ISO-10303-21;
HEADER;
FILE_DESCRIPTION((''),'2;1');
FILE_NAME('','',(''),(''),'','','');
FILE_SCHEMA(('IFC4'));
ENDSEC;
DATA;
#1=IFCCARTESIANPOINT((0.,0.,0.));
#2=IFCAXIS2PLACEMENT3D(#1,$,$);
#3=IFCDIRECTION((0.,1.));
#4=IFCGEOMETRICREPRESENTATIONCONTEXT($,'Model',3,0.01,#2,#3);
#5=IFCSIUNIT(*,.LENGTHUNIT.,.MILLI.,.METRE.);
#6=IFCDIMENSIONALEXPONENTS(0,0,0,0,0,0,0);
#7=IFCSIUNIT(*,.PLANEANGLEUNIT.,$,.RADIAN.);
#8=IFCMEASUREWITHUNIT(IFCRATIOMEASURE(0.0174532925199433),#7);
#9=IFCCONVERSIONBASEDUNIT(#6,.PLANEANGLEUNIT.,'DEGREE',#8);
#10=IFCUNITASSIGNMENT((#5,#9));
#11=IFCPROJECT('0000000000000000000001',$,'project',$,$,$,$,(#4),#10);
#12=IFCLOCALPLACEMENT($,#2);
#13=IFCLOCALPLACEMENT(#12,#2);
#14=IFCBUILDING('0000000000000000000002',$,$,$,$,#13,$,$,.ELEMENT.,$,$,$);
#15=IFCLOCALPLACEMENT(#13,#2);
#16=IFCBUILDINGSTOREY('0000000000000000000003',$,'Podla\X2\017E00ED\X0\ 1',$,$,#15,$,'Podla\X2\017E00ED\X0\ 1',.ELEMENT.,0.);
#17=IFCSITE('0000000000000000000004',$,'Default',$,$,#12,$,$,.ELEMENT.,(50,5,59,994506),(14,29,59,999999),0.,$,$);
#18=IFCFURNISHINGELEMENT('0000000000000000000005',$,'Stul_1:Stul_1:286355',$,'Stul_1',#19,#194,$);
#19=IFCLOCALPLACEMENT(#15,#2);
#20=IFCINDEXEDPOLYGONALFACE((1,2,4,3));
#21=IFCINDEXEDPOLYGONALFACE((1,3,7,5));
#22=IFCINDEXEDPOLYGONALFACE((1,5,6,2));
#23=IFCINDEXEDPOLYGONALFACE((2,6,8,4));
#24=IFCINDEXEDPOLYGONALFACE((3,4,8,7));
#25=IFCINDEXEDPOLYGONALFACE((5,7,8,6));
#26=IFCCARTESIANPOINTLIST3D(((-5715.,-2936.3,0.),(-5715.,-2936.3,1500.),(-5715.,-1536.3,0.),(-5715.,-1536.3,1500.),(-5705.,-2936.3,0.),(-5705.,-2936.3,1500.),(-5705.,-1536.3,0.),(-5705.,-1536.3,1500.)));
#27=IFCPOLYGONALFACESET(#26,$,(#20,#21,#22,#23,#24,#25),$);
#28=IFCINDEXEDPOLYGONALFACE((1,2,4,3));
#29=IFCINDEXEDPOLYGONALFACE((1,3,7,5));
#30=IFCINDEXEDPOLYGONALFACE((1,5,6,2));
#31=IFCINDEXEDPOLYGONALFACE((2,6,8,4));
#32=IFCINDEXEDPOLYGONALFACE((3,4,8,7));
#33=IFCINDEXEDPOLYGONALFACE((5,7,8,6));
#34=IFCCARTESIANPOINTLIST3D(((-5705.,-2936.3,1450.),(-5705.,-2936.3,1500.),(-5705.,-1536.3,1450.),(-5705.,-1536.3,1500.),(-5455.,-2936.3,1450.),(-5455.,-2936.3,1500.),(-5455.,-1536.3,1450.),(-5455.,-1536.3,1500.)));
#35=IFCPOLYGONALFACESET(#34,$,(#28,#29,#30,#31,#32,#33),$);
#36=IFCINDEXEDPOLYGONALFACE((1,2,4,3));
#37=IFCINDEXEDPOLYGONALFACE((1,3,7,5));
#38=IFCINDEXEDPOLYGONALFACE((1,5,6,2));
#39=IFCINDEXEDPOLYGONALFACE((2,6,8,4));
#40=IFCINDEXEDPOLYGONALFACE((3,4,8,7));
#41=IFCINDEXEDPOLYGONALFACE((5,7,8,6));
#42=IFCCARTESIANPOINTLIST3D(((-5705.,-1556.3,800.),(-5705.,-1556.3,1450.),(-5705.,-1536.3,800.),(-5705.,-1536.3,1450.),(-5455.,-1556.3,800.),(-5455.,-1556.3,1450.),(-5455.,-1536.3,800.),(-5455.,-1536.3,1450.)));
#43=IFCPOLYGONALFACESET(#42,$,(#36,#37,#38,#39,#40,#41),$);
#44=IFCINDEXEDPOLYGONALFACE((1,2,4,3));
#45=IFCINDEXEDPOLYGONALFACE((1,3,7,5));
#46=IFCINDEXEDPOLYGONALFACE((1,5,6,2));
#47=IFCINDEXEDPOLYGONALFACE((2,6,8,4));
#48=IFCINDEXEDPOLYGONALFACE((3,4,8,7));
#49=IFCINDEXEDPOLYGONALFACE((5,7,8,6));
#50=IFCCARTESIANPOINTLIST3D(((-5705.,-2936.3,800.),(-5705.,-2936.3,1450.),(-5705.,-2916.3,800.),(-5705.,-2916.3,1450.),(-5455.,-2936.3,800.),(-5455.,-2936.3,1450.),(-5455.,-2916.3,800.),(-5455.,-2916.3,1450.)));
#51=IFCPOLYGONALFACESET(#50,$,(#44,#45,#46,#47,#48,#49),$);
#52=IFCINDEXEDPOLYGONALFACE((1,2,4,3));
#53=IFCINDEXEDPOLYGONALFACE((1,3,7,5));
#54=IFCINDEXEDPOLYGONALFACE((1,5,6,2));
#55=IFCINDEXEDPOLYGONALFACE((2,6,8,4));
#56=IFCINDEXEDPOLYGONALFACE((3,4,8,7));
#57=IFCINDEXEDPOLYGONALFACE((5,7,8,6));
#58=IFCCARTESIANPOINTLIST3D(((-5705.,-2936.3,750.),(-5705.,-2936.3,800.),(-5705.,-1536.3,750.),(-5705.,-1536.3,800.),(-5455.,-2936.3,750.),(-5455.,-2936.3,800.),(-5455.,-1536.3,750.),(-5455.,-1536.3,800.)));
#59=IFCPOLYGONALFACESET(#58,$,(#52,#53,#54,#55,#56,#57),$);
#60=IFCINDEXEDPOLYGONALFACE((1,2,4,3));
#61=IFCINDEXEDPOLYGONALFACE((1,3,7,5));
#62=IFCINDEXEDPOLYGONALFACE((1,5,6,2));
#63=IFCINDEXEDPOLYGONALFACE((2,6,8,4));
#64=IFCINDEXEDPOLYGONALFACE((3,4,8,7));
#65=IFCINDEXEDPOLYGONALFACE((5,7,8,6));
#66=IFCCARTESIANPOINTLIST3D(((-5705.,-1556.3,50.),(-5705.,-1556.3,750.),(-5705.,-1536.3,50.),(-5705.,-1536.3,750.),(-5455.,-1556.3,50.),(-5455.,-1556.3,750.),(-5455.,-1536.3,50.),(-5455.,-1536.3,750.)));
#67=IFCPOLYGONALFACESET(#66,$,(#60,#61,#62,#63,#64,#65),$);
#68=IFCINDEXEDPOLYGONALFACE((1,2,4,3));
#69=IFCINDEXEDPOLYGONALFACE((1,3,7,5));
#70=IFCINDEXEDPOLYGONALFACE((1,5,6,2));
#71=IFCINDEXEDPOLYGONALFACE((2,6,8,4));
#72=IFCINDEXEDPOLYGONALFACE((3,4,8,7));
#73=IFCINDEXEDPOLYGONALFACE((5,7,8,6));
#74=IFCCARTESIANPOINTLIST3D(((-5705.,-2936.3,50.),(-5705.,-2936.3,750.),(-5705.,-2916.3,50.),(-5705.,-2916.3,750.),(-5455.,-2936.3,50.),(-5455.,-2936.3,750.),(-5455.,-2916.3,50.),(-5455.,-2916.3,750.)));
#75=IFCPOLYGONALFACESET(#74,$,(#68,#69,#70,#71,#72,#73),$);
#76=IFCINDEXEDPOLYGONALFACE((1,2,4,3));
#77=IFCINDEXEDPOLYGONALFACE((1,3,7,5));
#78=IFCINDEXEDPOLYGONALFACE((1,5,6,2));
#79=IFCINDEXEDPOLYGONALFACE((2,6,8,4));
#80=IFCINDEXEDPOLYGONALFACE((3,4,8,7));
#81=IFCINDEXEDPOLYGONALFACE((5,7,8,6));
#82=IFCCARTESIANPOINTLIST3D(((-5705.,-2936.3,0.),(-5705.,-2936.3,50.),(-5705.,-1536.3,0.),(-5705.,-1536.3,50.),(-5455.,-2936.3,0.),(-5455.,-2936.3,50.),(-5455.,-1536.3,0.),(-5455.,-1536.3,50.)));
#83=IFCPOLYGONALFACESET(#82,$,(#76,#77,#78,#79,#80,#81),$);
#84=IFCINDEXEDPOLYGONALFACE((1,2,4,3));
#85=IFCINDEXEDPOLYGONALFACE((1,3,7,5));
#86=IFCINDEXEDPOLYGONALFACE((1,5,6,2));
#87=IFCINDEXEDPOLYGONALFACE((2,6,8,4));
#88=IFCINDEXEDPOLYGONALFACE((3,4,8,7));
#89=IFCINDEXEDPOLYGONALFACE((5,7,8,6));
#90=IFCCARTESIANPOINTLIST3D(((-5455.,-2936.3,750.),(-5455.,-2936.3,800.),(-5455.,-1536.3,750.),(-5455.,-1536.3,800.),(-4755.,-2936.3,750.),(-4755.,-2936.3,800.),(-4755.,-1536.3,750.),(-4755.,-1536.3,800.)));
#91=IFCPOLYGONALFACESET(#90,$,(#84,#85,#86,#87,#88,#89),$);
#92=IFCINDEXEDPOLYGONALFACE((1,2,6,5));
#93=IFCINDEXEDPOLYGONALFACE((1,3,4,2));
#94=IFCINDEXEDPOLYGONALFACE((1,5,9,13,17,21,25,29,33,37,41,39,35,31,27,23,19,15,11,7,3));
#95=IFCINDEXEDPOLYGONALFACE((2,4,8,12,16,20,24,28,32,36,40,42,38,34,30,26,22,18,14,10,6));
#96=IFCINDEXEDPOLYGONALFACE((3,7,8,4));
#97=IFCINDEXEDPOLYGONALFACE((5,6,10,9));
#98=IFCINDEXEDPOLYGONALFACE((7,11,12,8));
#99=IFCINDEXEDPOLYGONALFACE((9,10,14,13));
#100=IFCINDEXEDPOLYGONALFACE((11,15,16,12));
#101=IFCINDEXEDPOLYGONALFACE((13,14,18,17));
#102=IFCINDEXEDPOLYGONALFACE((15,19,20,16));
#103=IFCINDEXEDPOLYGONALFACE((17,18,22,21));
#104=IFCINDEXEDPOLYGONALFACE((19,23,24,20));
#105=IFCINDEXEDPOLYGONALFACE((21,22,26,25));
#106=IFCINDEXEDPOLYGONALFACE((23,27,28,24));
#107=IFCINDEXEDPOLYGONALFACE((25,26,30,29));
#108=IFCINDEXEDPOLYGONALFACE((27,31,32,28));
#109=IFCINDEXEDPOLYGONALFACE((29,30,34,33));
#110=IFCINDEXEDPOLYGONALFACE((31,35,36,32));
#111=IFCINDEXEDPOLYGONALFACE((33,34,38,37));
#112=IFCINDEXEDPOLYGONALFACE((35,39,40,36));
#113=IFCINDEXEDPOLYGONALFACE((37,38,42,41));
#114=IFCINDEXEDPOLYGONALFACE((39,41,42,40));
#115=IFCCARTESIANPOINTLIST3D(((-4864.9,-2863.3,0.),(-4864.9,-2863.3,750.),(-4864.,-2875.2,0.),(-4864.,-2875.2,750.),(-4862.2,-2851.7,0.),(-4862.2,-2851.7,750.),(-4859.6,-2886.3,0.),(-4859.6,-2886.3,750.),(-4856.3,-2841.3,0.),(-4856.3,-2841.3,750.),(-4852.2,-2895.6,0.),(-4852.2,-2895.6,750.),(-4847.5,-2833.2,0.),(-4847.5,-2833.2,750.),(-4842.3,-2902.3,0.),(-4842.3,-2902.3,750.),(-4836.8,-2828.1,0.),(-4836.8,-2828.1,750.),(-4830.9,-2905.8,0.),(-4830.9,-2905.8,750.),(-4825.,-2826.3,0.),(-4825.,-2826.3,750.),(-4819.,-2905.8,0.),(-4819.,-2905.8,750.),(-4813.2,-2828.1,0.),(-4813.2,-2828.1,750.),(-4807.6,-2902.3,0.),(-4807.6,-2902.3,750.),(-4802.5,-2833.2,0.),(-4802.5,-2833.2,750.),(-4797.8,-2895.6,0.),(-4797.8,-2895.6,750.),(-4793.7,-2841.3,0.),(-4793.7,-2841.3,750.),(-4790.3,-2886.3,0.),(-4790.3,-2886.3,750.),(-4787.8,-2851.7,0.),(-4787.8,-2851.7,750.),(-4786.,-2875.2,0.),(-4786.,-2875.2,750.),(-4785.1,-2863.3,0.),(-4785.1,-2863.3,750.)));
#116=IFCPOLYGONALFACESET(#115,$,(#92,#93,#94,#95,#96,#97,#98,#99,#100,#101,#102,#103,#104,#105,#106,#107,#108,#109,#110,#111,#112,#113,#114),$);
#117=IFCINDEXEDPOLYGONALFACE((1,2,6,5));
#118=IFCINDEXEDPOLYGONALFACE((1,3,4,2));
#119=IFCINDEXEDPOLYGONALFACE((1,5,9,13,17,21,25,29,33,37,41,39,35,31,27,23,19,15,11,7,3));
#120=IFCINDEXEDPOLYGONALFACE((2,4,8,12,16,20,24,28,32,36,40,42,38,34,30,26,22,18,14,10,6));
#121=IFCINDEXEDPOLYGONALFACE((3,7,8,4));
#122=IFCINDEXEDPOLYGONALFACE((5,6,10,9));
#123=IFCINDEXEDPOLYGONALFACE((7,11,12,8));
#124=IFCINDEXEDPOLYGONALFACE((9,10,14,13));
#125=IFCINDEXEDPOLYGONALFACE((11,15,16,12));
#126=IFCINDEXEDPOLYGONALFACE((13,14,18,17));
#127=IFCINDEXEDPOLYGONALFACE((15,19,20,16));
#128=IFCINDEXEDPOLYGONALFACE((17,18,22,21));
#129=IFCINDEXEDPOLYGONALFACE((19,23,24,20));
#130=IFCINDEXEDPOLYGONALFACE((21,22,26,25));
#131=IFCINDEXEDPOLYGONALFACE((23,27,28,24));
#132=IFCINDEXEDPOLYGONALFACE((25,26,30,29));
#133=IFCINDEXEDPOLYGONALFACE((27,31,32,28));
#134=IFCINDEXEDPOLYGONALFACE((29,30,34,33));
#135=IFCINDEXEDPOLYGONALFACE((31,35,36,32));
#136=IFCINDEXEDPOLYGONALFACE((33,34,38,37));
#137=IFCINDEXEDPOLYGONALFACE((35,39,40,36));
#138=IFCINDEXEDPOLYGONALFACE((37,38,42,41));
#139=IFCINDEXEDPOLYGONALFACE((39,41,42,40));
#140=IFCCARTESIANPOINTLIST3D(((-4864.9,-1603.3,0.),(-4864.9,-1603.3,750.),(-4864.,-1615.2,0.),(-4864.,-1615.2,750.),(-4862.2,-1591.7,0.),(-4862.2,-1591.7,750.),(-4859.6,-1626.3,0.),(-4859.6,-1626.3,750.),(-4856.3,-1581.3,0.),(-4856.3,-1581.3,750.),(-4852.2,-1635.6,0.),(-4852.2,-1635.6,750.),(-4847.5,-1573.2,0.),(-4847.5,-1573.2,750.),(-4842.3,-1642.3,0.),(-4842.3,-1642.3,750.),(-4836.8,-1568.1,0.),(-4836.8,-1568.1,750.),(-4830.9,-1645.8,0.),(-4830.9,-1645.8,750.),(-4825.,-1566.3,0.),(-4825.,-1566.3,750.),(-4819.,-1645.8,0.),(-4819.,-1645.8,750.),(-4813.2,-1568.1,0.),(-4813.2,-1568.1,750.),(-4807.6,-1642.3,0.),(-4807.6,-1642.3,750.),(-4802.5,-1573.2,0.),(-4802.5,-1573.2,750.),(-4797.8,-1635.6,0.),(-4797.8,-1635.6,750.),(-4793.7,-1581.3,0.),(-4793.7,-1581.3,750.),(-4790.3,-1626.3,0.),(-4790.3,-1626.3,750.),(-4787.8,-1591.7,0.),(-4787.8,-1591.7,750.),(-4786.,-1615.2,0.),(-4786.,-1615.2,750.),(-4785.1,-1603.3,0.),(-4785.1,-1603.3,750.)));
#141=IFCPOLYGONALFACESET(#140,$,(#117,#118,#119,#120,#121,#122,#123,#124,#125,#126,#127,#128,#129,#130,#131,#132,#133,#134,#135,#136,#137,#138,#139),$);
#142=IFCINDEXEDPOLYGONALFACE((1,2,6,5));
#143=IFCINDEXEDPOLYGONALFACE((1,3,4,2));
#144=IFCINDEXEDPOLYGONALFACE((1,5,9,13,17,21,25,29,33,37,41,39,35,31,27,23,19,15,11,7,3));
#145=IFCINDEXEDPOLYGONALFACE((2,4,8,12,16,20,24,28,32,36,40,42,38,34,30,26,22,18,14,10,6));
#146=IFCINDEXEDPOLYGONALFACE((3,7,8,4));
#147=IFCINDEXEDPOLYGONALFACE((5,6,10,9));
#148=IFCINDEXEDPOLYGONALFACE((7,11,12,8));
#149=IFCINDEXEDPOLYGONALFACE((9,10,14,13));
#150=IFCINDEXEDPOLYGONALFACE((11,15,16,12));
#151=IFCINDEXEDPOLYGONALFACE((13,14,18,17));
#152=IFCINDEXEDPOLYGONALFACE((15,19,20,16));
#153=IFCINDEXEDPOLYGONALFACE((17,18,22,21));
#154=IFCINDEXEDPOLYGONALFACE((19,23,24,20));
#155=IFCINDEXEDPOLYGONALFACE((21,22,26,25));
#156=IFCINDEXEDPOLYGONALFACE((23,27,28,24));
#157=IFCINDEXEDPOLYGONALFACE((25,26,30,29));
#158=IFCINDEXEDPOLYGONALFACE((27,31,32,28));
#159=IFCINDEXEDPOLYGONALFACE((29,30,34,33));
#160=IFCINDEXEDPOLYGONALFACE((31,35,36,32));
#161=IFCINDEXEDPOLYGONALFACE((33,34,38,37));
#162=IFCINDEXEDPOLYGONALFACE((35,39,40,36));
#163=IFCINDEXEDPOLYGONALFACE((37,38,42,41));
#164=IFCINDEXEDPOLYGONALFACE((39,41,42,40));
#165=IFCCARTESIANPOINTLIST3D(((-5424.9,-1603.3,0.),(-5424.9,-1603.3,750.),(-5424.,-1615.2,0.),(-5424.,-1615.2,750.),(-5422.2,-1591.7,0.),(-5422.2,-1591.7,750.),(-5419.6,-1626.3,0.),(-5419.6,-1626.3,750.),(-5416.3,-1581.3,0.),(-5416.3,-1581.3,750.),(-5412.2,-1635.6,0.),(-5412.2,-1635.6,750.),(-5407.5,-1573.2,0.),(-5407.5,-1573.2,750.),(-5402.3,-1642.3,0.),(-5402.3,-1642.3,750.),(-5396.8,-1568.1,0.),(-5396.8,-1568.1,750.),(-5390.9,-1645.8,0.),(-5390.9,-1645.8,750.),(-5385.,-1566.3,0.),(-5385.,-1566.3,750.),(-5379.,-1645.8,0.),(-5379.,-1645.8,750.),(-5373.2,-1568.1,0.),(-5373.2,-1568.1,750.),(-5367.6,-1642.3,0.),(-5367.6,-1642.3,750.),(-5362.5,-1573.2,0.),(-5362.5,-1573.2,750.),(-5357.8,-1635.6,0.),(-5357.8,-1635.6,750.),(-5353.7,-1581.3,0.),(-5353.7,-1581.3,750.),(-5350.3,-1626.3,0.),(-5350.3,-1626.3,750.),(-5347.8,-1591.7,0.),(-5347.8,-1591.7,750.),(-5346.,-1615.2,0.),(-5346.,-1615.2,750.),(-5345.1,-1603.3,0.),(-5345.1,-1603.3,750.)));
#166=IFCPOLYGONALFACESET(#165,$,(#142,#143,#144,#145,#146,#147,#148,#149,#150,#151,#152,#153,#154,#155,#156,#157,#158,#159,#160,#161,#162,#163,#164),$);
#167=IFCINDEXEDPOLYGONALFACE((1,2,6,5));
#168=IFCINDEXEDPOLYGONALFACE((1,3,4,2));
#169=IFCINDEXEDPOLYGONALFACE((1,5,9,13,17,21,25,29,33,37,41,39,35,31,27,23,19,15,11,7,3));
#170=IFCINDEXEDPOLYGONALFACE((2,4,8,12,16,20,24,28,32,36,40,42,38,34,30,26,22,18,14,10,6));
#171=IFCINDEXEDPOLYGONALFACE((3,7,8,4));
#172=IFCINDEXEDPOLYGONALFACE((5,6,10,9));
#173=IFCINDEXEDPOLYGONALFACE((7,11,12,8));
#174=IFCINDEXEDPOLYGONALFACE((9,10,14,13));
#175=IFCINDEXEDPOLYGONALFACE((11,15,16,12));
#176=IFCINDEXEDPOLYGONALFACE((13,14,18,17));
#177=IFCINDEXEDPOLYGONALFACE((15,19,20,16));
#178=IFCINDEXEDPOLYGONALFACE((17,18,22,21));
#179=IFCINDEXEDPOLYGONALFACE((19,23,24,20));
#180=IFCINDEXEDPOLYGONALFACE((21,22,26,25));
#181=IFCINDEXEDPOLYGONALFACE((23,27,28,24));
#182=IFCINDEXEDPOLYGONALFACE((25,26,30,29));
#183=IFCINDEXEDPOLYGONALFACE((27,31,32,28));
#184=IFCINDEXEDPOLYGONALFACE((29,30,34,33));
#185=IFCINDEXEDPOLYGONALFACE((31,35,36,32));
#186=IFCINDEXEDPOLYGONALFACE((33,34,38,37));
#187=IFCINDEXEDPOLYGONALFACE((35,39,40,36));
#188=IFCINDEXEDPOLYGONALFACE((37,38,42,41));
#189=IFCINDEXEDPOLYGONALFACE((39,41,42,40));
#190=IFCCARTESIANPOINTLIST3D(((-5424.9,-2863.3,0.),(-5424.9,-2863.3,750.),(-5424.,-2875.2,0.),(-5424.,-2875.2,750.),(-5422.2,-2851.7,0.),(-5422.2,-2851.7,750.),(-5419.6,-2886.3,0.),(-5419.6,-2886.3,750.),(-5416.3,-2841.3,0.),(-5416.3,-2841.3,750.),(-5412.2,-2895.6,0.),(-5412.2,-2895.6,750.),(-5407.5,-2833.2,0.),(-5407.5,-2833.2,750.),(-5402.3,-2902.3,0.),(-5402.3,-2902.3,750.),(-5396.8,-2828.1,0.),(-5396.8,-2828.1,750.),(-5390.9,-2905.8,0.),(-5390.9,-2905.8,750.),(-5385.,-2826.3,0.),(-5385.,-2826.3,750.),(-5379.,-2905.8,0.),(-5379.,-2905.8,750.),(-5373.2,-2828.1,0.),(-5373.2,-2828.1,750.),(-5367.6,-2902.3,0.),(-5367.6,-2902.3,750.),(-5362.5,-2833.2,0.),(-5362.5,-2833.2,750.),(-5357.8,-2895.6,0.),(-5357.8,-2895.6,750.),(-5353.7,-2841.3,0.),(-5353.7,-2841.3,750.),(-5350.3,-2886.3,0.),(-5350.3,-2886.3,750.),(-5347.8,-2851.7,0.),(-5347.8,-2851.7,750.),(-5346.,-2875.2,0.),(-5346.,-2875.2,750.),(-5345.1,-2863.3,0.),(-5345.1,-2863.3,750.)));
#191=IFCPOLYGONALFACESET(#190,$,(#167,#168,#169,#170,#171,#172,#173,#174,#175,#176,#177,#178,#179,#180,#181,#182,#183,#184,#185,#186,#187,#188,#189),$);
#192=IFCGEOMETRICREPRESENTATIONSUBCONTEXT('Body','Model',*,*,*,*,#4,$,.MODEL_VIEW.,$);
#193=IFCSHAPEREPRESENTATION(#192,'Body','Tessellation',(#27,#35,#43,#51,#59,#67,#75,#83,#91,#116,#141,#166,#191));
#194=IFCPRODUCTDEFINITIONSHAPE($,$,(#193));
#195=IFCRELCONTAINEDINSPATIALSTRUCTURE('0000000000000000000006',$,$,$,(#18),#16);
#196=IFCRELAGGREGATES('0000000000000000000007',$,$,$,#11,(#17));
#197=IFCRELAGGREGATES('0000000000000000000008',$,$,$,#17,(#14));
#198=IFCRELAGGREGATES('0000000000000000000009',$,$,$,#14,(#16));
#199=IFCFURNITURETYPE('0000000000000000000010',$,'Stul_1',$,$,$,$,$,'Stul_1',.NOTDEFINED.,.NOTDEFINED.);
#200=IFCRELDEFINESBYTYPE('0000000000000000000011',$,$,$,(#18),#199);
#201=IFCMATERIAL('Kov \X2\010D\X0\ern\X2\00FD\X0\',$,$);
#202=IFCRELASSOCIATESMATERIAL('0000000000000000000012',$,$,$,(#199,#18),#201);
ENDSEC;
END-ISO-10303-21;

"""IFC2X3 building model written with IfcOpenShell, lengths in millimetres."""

from ifc_helpers import new_model, entity, si_unit, converted_unit, direction, frame, frame_2d, origin, origin_2d_with_axis, place, context, subcontext, project, spatial, rectangle, circle, extrude, source, transform, mapped, material, type_object, type_shapes, element, save


model = new_model("IFC2X3")

# Units and contexts
model_context = context("Model", 3, precision=0.01, world=origin(), true_north=direction((0.0, 1.0)))
body_context = subcontext(model_context, "Body", "Model", "MODEL_VIEW")
ifc_project = project(units=[si_unit("LENGTHUNIT", "METRE", prefix="MILLI"), converted_unit("PLANEANGLEUNIT", "DEGREE", entity("IfcRatioMeasure", 0.0174532925199433), si_unit("PLANEANGLEUNIT", "RADIAN"), dimensions=[0, 0, 0, 0, 0, 0, 0])], contexts=[model_context])

# Site, building, storey
site_placement = place(None, origin())
site = spatial("IfcSite", under=ifc_project, at=site_placement, Name="Default", CompositionType="ELEMENT", RefLatitude=(50, 5, 59, 994506), RefLongitude=(14, 29, 59, 999999), RefElevation=0.0)
building_placement = place(site_placement, origin())
building = spatial("IfcBuilding", under=site, at=building_placement, CompositionType="ELEMENT")
storey_placement = place(building_placement, origin())
storey = spatial("IfcBuildingStorey", under=building, at=storey_placement, Name="Podlaží 1", LongName="Podlaží 1", CompositionType="ELEMENT", Elevation=0.0)

# Furnishing element
ifc_material_1 = material(Name="Kov černý")
furniture_type = type_object("IfcFurnitureType", Name="Stul_1", ElementType="Stul_1", material=ifc_material_1)
shared_shape_1 = source(origin(), body_context, "Body", "SweptSolid", [
    extrude(rectangle(XDim=1400.0, YDim=10.0, at=origin_2d_with_axis()), frame((0.0, 605.0, 0.0), z_axis=(0.0, 0.0, 1.0), x_axis=(-1.0, 0.0, 0.0)), (0.0, 0.0, 1.0), 1500.0),
    extrude(rectangle(XDim=1400.0, YDim=250.0, at=frame_2d((0.0, 0.0), x_axis=(1.0, 0.0))), frame((0.0, 475.0, 1450.0), z_axis=(0.0, 0.0, 1.0), x_axis=(-1.0, 0.0, 0.0)), (0.0, 0.0, 1.0), 50.0),
    extrude(rectangle(XDim=20.0, YDim=250.0, at=origin_2d_with_axis()), frame((690.0, 475.0, 800.0), z_axis=(0.0, 0.0, 1.0), x_axis=(-1.0, 0.0, 0.0)), (0.0, 0.0, 1.0), 650.0),
    extrude(rectangle(XDim=20.0, YDim=250.0, at=frame_2d((0.0, 0.0), x_axis=(1.0, 0.0))), frame((-690.0, 475.0, 800.0), z_axis=(0.0, 0.0, 1.0), x_axis=(-1.0, 0.0, 0.0)), (0.0, 0.0, 1.0), 650.0),
    extrude(rectangle(XDim=1400.0, YDim=250.0, at=origin_2d_with_axis()), frame((0.0, 475.0, 750.0), z_axis=(0.0, 0.0, 1.0), x_axis=(-1.0, 0.0, 0.0)), (0.0, 0.0, 1.0), 50.0),
    extrude(rectangle(XDim=20.0, YDim=250.0, at=origin_2d_with_axis()), frame((690.0, 475.0, 50.0), z_axis=(0.0, 0.0, 1.0), x_axis=(-1.0, 0.0, 0.0)), (0.0, 0.0, 1.0), 700.0),
    extrude(rectangle(XDim=20.0, YDim=250.0, at=frame_2d((0.0, 0.0), x_axis=(1.0, 0.0))), frame((-690.0, 475.0, 50.0), z_axis=(0.0, 0.0, 1.0), x_axis=(-1.0, 0.0, 0.0)), (0.0, 0.0, 1.0), 700.0),
    extrude(rectangle(XDim=1400.0, YDim=250.0, at=origin_2d_with_axis()), frame((0.0, 475.0, 0.0), z_axis=(0.0, 0.0, 1.0), x_axis=(-1.0, 0.0, 0.0)), (0.0, 0.0, 1.0), 50.0),
    extrude(rectangle(XDim=1400.0, YDim=700.0, at=origin_2d_with_axis()), frame((0.0, 0.0, 750.0), z_axis=(0.0, 0.0, 1.0), x_axis=(-1.0, 0.0, 0.0)), (0.0, 0.0, 1.0), 50.0),
    extrude(circle(Radius=40.0, at=frame_2d((0.0, 0.0), x_axis=(1.0, 0.0))), frame((-630.0, -280.0, 0.0)), (0.0, 0.0, 1.0), 750.0),
    extrude(circle(Radius=40.0, at=frame_2d((0.0, 0.0), x_axis=(1.0, 0.0))), frame((630.0, -280.0, 0.0)), (0.0, 0.0, 1.0), 750.0),
    extrude(circle(Radius=40.0, at=frame_2d((0.0, 0.0), x_axis=(1.0, 0.0))), frame((630.0, 280.0, 0.0)), (0.0, 0.0, 1.0), 750.0),
    extrude(circle(Radius=40.0, at=frame_2d((0.0, 0.0), x_axis=(1.0, 0.0))), frame((-630.0, 280.0, 0.0)), (0.0, 0.0, 1.0), 750.0),
])
type_shapes(furniture_type, [shared_shape_1])
for number, where, z_axis, x_axis, name in (
    (1, (-5105.0, -2236.3, 0.0), (0.0, 0.0, 1.0), (0.0, 1.0, 0.0), "Stul_1:Stul_1:286355"),
):
    element("IfcFurnishingElement", number, at=place(storey_placement, frame(where, z_axis=z_axis, x_axis=x_axis)), inside=storey, type_object=furniture_type, material=ifc_material_1, Name=name, ObjectType="Stul_1", context=body_context, shape_type="MappedRepresentation", body=[
        mapped(shared_shape_1, transform((0.0, 0.0, 0.0), scale=1.0)),
    ])

save(model, "model.ifc")
